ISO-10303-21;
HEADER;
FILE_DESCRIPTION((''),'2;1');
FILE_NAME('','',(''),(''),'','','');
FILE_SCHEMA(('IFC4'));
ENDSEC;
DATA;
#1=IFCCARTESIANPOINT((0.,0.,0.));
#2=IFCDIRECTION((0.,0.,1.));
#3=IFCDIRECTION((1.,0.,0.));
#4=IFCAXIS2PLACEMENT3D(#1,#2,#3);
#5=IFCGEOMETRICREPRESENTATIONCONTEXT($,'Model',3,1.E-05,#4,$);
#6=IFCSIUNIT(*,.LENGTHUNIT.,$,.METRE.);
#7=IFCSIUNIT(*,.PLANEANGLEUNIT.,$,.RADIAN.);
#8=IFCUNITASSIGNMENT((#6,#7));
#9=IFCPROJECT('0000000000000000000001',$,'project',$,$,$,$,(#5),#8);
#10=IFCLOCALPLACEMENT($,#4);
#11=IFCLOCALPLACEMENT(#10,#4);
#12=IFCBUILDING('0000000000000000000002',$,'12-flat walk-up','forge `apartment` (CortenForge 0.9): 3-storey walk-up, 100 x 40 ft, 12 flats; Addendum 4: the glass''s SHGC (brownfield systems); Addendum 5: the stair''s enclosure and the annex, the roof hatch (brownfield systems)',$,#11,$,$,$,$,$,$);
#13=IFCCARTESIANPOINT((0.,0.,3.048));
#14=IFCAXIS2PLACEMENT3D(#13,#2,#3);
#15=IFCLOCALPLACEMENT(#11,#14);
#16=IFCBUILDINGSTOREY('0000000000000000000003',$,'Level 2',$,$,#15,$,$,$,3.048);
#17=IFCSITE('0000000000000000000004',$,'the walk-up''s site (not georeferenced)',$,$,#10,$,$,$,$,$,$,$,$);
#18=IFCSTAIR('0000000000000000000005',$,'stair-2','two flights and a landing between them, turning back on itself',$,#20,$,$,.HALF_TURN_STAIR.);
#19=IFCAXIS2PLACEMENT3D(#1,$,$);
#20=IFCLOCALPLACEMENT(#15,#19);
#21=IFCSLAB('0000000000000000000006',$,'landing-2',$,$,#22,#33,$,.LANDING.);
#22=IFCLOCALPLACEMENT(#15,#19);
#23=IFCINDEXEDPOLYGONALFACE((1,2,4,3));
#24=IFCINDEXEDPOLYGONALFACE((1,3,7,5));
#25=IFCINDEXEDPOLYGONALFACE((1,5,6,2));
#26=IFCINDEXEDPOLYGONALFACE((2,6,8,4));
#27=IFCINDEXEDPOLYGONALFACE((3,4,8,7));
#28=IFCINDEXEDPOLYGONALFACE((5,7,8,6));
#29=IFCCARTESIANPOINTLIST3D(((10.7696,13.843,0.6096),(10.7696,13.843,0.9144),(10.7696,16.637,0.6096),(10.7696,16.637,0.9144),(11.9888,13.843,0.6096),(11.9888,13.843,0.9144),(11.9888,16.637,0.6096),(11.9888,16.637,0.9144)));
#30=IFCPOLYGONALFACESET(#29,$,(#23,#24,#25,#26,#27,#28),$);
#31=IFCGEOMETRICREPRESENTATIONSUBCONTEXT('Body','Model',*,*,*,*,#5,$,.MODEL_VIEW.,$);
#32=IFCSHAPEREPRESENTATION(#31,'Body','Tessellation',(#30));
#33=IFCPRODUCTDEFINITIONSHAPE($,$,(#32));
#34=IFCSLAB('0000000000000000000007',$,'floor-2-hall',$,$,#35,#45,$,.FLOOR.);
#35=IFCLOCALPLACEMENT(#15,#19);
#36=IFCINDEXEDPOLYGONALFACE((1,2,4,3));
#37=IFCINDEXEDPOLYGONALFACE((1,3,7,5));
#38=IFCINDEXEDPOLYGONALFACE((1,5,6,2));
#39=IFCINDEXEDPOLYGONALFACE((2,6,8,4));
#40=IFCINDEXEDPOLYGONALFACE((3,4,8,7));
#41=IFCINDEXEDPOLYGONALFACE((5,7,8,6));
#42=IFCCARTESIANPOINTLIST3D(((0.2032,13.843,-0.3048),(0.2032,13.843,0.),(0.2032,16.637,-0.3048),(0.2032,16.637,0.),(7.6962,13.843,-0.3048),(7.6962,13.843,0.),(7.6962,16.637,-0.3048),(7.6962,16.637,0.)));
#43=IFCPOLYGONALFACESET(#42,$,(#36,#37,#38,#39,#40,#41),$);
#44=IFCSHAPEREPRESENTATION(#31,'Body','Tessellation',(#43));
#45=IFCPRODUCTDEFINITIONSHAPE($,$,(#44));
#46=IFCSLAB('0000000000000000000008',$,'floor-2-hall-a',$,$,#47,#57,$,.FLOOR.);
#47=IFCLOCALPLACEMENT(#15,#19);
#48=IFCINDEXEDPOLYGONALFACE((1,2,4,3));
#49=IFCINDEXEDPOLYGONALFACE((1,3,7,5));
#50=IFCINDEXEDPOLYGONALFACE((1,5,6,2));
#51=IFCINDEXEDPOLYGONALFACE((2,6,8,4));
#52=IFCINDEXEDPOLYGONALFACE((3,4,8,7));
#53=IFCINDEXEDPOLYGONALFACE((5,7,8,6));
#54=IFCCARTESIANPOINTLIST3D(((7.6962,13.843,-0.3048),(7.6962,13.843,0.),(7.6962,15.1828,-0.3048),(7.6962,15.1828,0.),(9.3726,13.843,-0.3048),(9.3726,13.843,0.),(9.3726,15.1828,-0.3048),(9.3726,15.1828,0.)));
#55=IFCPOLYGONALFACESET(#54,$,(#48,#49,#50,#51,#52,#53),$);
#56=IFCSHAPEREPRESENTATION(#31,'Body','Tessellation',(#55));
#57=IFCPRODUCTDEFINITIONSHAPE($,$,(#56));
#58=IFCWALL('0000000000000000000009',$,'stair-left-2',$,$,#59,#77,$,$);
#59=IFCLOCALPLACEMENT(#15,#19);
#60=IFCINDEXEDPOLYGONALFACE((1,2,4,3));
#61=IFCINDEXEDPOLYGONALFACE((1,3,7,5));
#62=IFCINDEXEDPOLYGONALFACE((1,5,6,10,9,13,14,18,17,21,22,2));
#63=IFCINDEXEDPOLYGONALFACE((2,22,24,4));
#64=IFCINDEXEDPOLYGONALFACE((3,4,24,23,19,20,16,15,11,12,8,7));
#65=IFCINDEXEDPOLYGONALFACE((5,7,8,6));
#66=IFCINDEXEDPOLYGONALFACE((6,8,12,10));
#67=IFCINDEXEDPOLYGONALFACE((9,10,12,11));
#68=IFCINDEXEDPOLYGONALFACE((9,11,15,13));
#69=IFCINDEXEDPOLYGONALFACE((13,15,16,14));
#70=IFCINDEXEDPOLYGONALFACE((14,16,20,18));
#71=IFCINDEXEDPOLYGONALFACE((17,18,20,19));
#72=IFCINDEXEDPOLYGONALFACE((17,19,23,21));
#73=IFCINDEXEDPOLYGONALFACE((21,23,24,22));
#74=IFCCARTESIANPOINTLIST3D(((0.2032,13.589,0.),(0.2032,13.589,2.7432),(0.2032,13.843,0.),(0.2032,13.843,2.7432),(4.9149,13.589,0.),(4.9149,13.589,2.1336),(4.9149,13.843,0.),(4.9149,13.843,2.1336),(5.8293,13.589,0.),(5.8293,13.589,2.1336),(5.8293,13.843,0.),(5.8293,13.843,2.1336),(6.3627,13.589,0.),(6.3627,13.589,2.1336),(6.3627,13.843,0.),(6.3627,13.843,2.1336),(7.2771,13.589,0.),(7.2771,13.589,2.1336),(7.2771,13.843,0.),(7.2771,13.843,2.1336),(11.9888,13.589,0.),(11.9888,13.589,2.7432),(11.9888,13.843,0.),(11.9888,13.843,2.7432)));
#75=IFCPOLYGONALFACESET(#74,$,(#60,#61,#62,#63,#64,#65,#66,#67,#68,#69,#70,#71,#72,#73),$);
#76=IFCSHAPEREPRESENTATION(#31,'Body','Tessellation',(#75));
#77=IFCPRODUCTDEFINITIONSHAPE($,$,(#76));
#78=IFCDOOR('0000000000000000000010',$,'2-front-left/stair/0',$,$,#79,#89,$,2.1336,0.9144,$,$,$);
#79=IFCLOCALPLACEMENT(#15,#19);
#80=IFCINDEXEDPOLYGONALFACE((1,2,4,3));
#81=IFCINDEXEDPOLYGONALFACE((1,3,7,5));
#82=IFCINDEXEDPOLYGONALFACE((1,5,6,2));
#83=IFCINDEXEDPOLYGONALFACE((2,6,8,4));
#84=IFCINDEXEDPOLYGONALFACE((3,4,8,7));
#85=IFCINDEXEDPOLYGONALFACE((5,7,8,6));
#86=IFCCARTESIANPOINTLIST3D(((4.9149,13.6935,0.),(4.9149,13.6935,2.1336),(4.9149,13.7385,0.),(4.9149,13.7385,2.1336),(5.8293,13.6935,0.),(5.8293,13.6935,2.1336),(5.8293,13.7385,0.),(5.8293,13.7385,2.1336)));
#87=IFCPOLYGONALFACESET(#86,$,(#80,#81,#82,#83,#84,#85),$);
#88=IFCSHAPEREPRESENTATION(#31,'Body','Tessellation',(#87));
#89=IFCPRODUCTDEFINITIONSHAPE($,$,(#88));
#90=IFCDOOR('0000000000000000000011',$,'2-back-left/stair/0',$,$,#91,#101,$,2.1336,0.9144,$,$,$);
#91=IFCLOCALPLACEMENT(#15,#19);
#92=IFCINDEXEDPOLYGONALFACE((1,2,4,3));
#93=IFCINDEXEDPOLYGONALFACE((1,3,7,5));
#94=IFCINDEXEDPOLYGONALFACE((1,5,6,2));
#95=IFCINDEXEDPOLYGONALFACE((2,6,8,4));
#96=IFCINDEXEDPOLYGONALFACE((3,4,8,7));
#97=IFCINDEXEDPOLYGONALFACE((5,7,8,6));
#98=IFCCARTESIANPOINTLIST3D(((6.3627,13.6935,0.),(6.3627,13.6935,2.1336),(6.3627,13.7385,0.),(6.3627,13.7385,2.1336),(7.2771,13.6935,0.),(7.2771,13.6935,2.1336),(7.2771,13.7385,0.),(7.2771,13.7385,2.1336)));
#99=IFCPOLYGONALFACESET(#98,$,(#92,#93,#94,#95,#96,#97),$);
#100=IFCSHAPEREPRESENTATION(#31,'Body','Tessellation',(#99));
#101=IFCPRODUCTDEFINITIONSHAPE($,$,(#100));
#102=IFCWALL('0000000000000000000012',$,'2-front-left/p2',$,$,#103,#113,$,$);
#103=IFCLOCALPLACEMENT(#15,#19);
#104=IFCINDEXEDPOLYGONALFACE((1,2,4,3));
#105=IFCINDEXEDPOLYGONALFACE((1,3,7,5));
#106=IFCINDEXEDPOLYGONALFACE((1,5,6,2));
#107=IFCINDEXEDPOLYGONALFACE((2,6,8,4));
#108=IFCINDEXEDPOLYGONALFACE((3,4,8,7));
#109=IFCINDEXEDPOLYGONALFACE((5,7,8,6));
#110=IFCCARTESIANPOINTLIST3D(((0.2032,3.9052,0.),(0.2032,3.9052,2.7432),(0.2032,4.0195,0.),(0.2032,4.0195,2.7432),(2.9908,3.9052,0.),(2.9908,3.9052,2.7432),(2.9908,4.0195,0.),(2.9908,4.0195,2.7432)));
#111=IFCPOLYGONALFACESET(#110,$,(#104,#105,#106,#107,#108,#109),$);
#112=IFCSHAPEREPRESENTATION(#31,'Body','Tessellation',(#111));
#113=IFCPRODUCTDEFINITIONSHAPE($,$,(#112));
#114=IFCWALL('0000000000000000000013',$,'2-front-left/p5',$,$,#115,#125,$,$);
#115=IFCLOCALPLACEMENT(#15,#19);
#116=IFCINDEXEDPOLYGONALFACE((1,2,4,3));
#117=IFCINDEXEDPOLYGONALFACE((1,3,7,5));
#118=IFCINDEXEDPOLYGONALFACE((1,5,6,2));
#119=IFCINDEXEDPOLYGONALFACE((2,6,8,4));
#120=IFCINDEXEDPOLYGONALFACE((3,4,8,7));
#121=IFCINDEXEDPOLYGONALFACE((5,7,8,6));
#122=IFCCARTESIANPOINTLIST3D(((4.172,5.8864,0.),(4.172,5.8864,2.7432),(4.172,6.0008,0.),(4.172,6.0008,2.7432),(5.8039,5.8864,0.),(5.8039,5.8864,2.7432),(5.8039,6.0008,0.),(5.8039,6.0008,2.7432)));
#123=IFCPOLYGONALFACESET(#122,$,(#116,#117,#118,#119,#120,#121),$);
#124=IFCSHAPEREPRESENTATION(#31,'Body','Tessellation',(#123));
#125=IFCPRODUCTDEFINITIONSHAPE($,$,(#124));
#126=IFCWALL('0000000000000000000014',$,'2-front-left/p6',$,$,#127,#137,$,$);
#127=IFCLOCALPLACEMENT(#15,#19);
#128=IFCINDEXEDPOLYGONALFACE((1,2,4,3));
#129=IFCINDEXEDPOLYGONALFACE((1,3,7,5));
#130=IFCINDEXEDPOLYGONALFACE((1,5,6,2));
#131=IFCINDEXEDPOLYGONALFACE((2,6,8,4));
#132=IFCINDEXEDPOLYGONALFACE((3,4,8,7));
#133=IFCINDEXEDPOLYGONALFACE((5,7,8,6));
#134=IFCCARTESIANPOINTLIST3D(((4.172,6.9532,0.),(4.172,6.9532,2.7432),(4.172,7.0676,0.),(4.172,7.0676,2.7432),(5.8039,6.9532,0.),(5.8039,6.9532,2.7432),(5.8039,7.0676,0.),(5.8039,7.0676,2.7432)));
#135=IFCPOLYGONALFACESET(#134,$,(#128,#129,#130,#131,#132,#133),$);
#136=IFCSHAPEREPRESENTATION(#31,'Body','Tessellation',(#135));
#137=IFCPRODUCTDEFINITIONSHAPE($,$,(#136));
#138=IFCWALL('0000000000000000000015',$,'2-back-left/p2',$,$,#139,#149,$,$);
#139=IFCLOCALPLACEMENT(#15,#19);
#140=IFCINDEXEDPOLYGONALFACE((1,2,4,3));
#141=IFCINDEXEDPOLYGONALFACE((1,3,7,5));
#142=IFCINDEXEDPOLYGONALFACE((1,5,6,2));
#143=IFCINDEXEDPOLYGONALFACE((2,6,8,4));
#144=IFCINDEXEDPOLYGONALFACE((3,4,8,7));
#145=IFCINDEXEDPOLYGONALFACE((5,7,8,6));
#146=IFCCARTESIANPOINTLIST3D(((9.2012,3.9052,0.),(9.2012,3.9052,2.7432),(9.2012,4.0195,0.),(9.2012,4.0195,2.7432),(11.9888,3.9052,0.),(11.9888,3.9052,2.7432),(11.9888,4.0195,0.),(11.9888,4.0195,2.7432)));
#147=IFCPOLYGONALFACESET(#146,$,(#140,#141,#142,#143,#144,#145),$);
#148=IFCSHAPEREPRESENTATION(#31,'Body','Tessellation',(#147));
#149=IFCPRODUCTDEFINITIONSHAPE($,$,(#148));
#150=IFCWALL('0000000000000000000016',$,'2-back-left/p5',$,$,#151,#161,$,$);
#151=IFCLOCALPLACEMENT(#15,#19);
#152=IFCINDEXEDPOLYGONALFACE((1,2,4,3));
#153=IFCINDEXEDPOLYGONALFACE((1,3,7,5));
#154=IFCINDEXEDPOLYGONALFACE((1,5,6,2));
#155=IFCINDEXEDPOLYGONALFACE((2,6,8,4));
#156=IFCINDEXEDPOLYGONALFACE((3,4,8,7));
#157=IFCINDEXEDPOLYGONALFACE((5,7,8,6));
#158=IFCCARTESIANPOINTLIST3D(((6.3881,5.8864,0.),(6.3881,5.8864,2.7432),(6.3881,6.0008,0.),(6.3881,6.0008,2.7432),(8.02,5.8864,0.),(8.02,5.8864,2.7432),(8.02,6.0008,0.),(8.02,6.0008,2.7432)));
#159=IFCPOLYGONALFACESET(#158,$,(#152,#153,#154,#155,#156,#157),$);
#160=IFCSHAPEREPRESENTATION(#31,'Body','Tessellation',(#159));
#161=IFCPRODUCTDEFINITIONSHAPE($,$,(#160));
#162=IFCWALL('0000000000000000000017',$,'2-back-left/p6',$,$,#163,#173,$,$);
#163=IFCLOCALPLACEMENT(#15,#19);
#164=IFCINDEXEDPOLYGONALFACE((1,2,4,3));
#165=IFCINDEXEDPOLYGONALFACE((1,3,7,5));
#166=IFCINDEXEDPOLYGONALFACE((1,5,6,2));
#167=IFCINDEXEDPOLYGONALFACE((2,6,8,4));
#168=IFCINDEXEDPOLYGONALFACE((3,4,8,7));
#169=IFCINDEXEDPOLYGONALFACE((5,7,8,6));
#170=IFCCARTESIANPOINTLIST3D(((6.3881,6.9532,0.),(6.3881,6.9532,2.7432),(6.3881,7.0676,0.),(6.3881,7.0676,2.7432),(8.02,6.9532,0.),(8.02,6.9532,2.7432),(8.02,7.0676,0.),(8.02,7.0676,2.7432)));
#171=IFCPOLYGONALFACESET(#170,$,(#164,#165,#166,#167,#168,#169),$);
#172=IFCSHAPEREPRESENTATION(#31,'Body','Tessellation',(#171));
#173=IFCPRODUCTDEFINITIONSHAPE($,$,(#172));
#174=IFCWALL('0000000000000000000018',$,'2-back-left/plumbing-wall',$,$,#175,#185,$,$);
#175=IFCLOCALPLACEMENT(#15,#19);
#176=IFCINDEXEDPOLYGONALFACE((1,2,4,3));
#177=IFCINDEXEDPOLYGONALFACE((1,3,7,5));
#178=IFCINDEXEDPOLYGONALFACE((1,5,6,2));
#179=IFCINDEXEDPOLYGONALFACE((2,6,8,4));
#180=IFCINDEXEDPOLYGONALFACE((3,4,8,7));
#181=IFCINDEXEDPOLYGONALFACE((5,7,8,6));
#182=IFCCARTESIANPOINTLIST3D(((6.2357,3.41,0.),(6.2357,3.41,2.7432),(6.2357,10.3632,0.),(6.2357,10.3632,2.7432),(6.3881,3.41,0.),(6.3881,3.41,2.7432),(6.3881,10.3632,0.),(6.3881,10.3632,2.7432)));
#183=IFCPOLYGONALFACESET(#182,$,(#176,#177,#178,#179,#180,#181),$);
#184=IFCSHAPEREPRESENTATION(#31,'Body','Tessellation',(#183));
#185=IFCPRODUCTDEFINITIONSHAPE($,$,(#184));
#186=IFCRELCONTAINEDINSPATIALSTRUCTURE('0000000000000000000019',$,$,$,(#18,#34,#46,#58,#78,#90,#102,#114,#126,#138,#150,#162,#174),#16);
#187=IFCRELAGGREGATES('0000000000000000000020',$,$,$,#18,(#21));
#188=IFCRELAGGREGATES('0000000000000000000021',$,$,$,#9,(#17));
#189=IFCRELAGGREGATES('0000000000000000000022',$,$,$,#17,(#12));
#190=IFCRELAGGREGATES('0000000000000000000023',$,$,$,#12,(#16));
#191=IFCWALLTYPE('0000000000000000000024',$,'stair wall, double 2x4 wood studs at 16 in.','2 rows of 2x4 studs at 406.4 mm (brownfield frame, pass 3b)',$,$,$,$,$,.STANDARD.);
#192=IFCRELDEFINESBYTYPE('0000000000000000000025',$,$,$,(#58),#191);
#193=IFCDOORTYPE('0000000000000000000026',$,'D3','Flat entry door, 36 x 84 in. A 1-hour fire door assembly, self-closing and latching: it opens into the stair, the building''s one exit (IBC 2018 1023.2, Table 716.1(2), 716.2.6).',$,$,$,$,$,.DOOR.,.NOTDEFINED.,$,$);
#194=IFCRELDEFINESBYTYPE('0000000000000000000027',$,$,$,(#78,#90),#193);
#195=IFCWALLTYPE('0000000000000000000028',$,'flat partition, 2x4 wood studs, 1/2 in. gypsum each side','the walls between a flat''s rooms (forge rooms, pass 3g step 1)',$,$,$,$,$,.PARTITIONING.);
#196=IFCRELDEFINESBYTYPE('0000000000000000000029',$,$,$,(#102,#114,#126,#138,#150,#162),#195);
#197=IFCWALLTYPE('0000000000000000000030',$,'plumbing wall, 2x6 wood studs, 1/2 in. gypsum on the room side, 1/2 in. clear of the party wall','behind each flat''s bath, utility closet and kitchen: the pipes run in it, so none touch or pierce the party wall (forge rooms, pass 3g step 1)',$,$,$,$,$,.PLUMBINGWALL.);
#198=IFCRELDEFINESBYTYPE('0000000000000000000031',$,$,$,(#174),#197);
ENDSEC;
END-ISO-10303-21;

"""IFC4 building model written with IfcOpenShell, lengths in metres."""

from ifc_helpers import new_model, si_unit, frame, frame_2d, origin, origin_with_axes, place, context, subcontext, project, spatial, rectangle, extrude, type_object, element, fill, aggregate, save


model = new_model("IFC4")

# Units and contexts
model_context = context("Model", 3, precision=1e-05, world=origin_with_axes())
body_context = subcontext(model_context, "Body", "Model", "MODEL_VIEW")
ifc_project = project(units=[si_unit("LENGTHUNIT", "METRE"), si_unit("PLANEANGLEUNIT", "RADIAN")], contexts=[model_context])

# Site, building, storey
site_placement = place(None, origin_with_axes())
site = spatial("IfcSite", under=ifc_project, at=site_placement, Name="the walk-up's site (not georeferenced)")
building_placement = place(site_placement, origin_with_axes())
building = spatial("IfcBuilding", under=site, at=building_placement, Name="12-flat walk-up", Description="forge `apartment` (CortenForge 0.9): 3-storey walk-up, 100 x 40 ft, 12 flats; Addendum 4: the glass's SHGC (brownfield systems); Addendum 5: the stair's enclosure and the annex, the roof hatch (brownfield systems)")
storey_placement = place(building_placement, frame((0.0, 0.0, 3.048), z_axis=(0.0, 0.0, 1.0), x_axis=(1.0, 0.0, 0.0)))
storey = spatial("IfcBuildingStorey", under=building, at=storey_placement, Name="Level 2", Elevation=3.048)

# Stair, slab
stair_placement = place(storey_placement, frame((0.0, 0.0, -3.048), z_axis=(0.0, 0.0, 1.0), x_axis=(1.0, 0.0, 0.0)))
stair = element("IfcStair", 1, at=stair_placement, inside=storey, Name="stair-2", Description="two flights and a landing between them, turning back on itself", PredefinedType="HALF_TURN_STAIR")
slab_1_placement = place(stair_placement, frame((10.7696, 13.843, 3.6576), z_axis=(0.0, 0.0, 1.0), x_axis=(1.0, 0.0, 0.0)))
slab_1 = element("IfcSlab", 2, at=slab_1_placement, Name="landing-2", PredefinedType="LANDING", context=body_context, shape_type="SweptSolid", body=[
    extrude(rectangle(XDim=1.2192, YDim=2.794, at=frame_2d((0.6096, 1.397))), origin(), (0.0, 0.0, 1.0), 0.3048),
])

# Slabs
slab_2_placement = place(storey_placement, frame((0.2032, 13.843, -0.3048), z_axis=(0.0, 0.0, 1.0), x_axis=(1.0, 0.0, 0.0)))
element("IfcSlab", 3, at=slab_2_placement, inside=storey, Name="floor-2-hall", PredefinedType="FLOOR", context=body_context, shape_type="SweptSolid", body=[
    extrude(rectangle(XDim=7.493, YDim=2.794, at=frame_2d((3.7465, 1.397))), origin(), (0.0, 0.0, 1.0), 0.3048),
])
slab_3_placement = place(storey_placement, frame((7.6962, 13.843, -0.3048), z_axis=(0.0, 0.0, 1.0), x_axis=(1.0, 0.0, 0.0)))
element("IfcSlab", 4, at=slab_3_placement, inside=storey, Name="floor-2-hall-a", PredefinedType="FLOOR", context=body_context, shape_type="SweptSolid", body=[
    extrude(rectangle(XDim=1.6764, YDim=1.3399, at=frame_2d((0.8382, 0.6699))), origin(), (0.0, 0.0, 1.0), 0.3048),
])

# Wall, openings, doors
wall_type_1 = type_object("IfcWallType", Name="stair wall, double 2x4 wood studs at 16 in.", Description="2 rows of 2x4 studs at 406.4 mm (brownfield frame, pass 3b)", PredefinedType="STANDARD")
wall_1_placement = place(storey_placement, frame((0.2032, 13.589, 0.0), z_axis=(0.0, 0.0, 1.0), x_axis=(1.0, 0.0, 0.0)))
wall_1 = element("IfcWall", 5, at=wall_1_placement, inside=storey, type_object=wall_type_1, Name="stair-left-2", context=body_context, shape_type="SweptSolid", body=[
    extrude(rectangle(XDim=11.7856, YDim=0.254, at=frame_2d((5.8928, 0.127))), origin(), (0.0, 0.0, 1.0), 2.7432),
])
opening_1_placement = place(wall_1_placement, frame((4.7117, 0.0, 0.0), z_axis=(0.0, 0.0, 1.0), x_axis=(1.0, 0.0, 0.0)))
opening_1 = element("IfcOpeningElement", 6, at=opening_1_placement, cuts=wall_1, PredefinedType="OPENING", context=body_context, shape_type="SweptSolid", body=[
    extrude(rectangle(XDim=0.9144, YDim=0.254, at=frame_2d((0.4572, 0.127))), origin(), (0.0, 0.0, 1.0), 2.1336),
])
opening_2_placement = place(wall_1_placement, frame((6.1595, 0.0, 0.0), z_axis=(0.0, 0.0, 1.0), x_axis=(1.0, 0.0, 0.0)))
opening_2 = element("IfcOpeningElement", 7, at=opening_2_placement, cuts=wall_1, PredefinedType="OPENING", context=body_context, shape_type="SweptSolid", body=[
    extrude(rectangle(XDim=0.9144, YDim=0.254, at=frame_2d((0.4572, 0.127))), origin(), (0.0, 0.0, 1.0), 2.1336),
])
door_type = type_object("IfcDoorType", Name="D3", Description="Flat entry door, 36 x 84 in. A 1-hour fire door assembly, self-closing and latching: it opens into the stair, the building's one exit (IBC 2018 1023.2, Table 716.1(2), 716.2.6).", OperationType="NOTDEFINED", PredefinedType="DOOR")
door_1_placement = place(opening_1_placement, frame((0.0, 0.1045, 0.0), z_axis=(0.0, 0.0, 1.0), x_axis=(1.0, 0.0, 0.0)))
door_1 = element("IfcDoor", 8, at=door_1_placement, inside=storey, type_object=door_type, Name="2-front-left/stair/0", OverallHeight=2.1336, OverallWidth=0.9144, context=body_context, shape_type="SweptSolid", body=[
    extrude(rectangle(XDim=0.9144, YDim=0.045, at=frame_2d((0.4572, 0.0225))), origin(), (0.0, 0.0, 1.0), 2.1336),
])
fill(opening_1, door_1)
door_2_placement = place(opening_2_placement, frame((0.0, 0.1045, 0.0), z_axis=(0.0, 0.0, 1.0), x_axis=(1.0, 0.0, 0.0)))
door_2 = element("IfcDoor", 9, at=door_2_placement, inside=storey, type_object=door_type, Name="2-back-left/stair/0", OverallHeight=2.1336, OverallWidth=0.9144, context=body_context, shape_type="SweptSolid", body=[
    extrude(rectangle(XDim=0.9144, YDim=0.045, at=frame_2d((0.4572, 0.0225))), origin(), (0.0, 0.0, 1.0), 2.1336),
])
fill(opening_2, door_2)

# Walls
wall_type_2 = type_object("IfcWallType", Name="flat partition, 2x4 wood studs, 1/2 in. gypsum each side", Description="the walls between a flat's rooms (forge rooms, pass 3g step 1)", PredefinedType="PARTITIONING")
wall_2_placement = place(storey_placement, frame((0.2032, 3.9052, 0.0), z_axis=(0.0, 0.0, 1.0), x_axis=(1.0, 0.0, 0.0)))
element("IfcWall", 10, at=wall_2_placement, inside=storey, type_object=wall_type_2, Name="2-front-left/p2", context=body_context, shape_type="SweptSolid", body=[
    extrude(rectangle(XDim=2.7877, YDim=0.1143, at=frame_2d((1.3938, 0.0571))), origin(), (0.0, 0.0, 1.0), 2.7432),
])
for number, where, z_axis, x_axis, name in (
    (11, (4.1719, 5.8864, 0.0), (0.0, 0.0, 1.0), (1.0, 0.0, 0.0), "2-front-left/p5"),
    (12, (4.1719, 6.9532, 0.0), (0.0, 0.0, 1.0), (1.0, 0.0, 0.0), "2-front-left/p6"),
):
    element("IfcWall", number, at=place(storey_placement, frame(where, z_axis=z_axis, x_axis=x_axis)), inside=storey, type_object=wall_type_2, Name=name, context=body_context, shape_type="SweptSolid", body=[
        extrude(rectangle(XDim=1.6319, YDim=0.1143, at=frame_2d((0.816, 0.0572))), origin(), (0.0, 0.0, 1.0), 2.7432),
    ])
wall_3_placement = place(storey_placement, frame((9.2012, 3.9052, 0.0), z_axis=(0.0, 0.0, 1.0), x_axis=(1.0, 0.0, 0.0)))
element("IfcWall", 13, at=wall_3_placement, inside=storey, type_object=wall_type_2, Name="2-back-left/p2", context=body_context, shape_type="SweptSolid", body=[
    extrude(rectangle(XDim=2.7876, YDim=0.1143, at=frame_2d((1.3938, 0.0571))), origin(), (0.0, 0.0, 1.0), 2.7432),
])
for number, where, z_axis, x_axis, name in (
    (14, (6.3881, 5.8864, 0.0), (0.0, 0.0, 1.0), (1.0, 0.0, 0.0), "2-back-left/p5"),
    (15, (6.3881, 6.9532, 0.0), (0.0, 0.0, 1.0), (1.0, 0.0, 0.0), "2-back-left/p6"),
):
    element("IfcWall", number, at=place(storey_placement, frame(where, z_axis=z_axis, x_axis=x_axis)), inside=storey, type_object=wall_type_2, Name=name, context=body_context, shape_type="SweptSolid", body=[
        extrude(rectangle(XDim=1.6319, YDim=0.1143, at=frame_2d((0.816, 0.0572))), origin(), (0.0, 0.0, 1.0), 2.7432),
    ])
wall_type_3 = type_object("IfcWallType", Name="plumbing wall, 2x6 wood studs, 1/2 in. gypsum on the room side, 1/2 in. clear of the party wall", Description="behind each flat's bath, utility closet and kitchen: the pipes run in it, so none touch or pierce the party wall (forge rooms, pass 3g step 1)", PredefinedType="PLUMBINGWALL")
wall_4_placement = place(storey_placement, frame((6.2357, 3.41, 0.0), z_axis=(0.0, 0.0, 1.0), x_axis=(1.0, 0.0, 0.0)))
element("IfcWall", 16, at=wall_4_placement, inside=storey, type_object=wall_type_3, Name="2-back-left/plumbing-wall", context=body_context, shape_type="SweptSolid", body=[
    extrude(rectangle(XDim=0.1524, YDim=6.9533, at=frame_2d((0.0762, 3.4766))), origin(), (0.0, 0.0, 1.0), 2.7432),
])

aggregate(stair, [slab_1])

save(model, "model.ifc")
